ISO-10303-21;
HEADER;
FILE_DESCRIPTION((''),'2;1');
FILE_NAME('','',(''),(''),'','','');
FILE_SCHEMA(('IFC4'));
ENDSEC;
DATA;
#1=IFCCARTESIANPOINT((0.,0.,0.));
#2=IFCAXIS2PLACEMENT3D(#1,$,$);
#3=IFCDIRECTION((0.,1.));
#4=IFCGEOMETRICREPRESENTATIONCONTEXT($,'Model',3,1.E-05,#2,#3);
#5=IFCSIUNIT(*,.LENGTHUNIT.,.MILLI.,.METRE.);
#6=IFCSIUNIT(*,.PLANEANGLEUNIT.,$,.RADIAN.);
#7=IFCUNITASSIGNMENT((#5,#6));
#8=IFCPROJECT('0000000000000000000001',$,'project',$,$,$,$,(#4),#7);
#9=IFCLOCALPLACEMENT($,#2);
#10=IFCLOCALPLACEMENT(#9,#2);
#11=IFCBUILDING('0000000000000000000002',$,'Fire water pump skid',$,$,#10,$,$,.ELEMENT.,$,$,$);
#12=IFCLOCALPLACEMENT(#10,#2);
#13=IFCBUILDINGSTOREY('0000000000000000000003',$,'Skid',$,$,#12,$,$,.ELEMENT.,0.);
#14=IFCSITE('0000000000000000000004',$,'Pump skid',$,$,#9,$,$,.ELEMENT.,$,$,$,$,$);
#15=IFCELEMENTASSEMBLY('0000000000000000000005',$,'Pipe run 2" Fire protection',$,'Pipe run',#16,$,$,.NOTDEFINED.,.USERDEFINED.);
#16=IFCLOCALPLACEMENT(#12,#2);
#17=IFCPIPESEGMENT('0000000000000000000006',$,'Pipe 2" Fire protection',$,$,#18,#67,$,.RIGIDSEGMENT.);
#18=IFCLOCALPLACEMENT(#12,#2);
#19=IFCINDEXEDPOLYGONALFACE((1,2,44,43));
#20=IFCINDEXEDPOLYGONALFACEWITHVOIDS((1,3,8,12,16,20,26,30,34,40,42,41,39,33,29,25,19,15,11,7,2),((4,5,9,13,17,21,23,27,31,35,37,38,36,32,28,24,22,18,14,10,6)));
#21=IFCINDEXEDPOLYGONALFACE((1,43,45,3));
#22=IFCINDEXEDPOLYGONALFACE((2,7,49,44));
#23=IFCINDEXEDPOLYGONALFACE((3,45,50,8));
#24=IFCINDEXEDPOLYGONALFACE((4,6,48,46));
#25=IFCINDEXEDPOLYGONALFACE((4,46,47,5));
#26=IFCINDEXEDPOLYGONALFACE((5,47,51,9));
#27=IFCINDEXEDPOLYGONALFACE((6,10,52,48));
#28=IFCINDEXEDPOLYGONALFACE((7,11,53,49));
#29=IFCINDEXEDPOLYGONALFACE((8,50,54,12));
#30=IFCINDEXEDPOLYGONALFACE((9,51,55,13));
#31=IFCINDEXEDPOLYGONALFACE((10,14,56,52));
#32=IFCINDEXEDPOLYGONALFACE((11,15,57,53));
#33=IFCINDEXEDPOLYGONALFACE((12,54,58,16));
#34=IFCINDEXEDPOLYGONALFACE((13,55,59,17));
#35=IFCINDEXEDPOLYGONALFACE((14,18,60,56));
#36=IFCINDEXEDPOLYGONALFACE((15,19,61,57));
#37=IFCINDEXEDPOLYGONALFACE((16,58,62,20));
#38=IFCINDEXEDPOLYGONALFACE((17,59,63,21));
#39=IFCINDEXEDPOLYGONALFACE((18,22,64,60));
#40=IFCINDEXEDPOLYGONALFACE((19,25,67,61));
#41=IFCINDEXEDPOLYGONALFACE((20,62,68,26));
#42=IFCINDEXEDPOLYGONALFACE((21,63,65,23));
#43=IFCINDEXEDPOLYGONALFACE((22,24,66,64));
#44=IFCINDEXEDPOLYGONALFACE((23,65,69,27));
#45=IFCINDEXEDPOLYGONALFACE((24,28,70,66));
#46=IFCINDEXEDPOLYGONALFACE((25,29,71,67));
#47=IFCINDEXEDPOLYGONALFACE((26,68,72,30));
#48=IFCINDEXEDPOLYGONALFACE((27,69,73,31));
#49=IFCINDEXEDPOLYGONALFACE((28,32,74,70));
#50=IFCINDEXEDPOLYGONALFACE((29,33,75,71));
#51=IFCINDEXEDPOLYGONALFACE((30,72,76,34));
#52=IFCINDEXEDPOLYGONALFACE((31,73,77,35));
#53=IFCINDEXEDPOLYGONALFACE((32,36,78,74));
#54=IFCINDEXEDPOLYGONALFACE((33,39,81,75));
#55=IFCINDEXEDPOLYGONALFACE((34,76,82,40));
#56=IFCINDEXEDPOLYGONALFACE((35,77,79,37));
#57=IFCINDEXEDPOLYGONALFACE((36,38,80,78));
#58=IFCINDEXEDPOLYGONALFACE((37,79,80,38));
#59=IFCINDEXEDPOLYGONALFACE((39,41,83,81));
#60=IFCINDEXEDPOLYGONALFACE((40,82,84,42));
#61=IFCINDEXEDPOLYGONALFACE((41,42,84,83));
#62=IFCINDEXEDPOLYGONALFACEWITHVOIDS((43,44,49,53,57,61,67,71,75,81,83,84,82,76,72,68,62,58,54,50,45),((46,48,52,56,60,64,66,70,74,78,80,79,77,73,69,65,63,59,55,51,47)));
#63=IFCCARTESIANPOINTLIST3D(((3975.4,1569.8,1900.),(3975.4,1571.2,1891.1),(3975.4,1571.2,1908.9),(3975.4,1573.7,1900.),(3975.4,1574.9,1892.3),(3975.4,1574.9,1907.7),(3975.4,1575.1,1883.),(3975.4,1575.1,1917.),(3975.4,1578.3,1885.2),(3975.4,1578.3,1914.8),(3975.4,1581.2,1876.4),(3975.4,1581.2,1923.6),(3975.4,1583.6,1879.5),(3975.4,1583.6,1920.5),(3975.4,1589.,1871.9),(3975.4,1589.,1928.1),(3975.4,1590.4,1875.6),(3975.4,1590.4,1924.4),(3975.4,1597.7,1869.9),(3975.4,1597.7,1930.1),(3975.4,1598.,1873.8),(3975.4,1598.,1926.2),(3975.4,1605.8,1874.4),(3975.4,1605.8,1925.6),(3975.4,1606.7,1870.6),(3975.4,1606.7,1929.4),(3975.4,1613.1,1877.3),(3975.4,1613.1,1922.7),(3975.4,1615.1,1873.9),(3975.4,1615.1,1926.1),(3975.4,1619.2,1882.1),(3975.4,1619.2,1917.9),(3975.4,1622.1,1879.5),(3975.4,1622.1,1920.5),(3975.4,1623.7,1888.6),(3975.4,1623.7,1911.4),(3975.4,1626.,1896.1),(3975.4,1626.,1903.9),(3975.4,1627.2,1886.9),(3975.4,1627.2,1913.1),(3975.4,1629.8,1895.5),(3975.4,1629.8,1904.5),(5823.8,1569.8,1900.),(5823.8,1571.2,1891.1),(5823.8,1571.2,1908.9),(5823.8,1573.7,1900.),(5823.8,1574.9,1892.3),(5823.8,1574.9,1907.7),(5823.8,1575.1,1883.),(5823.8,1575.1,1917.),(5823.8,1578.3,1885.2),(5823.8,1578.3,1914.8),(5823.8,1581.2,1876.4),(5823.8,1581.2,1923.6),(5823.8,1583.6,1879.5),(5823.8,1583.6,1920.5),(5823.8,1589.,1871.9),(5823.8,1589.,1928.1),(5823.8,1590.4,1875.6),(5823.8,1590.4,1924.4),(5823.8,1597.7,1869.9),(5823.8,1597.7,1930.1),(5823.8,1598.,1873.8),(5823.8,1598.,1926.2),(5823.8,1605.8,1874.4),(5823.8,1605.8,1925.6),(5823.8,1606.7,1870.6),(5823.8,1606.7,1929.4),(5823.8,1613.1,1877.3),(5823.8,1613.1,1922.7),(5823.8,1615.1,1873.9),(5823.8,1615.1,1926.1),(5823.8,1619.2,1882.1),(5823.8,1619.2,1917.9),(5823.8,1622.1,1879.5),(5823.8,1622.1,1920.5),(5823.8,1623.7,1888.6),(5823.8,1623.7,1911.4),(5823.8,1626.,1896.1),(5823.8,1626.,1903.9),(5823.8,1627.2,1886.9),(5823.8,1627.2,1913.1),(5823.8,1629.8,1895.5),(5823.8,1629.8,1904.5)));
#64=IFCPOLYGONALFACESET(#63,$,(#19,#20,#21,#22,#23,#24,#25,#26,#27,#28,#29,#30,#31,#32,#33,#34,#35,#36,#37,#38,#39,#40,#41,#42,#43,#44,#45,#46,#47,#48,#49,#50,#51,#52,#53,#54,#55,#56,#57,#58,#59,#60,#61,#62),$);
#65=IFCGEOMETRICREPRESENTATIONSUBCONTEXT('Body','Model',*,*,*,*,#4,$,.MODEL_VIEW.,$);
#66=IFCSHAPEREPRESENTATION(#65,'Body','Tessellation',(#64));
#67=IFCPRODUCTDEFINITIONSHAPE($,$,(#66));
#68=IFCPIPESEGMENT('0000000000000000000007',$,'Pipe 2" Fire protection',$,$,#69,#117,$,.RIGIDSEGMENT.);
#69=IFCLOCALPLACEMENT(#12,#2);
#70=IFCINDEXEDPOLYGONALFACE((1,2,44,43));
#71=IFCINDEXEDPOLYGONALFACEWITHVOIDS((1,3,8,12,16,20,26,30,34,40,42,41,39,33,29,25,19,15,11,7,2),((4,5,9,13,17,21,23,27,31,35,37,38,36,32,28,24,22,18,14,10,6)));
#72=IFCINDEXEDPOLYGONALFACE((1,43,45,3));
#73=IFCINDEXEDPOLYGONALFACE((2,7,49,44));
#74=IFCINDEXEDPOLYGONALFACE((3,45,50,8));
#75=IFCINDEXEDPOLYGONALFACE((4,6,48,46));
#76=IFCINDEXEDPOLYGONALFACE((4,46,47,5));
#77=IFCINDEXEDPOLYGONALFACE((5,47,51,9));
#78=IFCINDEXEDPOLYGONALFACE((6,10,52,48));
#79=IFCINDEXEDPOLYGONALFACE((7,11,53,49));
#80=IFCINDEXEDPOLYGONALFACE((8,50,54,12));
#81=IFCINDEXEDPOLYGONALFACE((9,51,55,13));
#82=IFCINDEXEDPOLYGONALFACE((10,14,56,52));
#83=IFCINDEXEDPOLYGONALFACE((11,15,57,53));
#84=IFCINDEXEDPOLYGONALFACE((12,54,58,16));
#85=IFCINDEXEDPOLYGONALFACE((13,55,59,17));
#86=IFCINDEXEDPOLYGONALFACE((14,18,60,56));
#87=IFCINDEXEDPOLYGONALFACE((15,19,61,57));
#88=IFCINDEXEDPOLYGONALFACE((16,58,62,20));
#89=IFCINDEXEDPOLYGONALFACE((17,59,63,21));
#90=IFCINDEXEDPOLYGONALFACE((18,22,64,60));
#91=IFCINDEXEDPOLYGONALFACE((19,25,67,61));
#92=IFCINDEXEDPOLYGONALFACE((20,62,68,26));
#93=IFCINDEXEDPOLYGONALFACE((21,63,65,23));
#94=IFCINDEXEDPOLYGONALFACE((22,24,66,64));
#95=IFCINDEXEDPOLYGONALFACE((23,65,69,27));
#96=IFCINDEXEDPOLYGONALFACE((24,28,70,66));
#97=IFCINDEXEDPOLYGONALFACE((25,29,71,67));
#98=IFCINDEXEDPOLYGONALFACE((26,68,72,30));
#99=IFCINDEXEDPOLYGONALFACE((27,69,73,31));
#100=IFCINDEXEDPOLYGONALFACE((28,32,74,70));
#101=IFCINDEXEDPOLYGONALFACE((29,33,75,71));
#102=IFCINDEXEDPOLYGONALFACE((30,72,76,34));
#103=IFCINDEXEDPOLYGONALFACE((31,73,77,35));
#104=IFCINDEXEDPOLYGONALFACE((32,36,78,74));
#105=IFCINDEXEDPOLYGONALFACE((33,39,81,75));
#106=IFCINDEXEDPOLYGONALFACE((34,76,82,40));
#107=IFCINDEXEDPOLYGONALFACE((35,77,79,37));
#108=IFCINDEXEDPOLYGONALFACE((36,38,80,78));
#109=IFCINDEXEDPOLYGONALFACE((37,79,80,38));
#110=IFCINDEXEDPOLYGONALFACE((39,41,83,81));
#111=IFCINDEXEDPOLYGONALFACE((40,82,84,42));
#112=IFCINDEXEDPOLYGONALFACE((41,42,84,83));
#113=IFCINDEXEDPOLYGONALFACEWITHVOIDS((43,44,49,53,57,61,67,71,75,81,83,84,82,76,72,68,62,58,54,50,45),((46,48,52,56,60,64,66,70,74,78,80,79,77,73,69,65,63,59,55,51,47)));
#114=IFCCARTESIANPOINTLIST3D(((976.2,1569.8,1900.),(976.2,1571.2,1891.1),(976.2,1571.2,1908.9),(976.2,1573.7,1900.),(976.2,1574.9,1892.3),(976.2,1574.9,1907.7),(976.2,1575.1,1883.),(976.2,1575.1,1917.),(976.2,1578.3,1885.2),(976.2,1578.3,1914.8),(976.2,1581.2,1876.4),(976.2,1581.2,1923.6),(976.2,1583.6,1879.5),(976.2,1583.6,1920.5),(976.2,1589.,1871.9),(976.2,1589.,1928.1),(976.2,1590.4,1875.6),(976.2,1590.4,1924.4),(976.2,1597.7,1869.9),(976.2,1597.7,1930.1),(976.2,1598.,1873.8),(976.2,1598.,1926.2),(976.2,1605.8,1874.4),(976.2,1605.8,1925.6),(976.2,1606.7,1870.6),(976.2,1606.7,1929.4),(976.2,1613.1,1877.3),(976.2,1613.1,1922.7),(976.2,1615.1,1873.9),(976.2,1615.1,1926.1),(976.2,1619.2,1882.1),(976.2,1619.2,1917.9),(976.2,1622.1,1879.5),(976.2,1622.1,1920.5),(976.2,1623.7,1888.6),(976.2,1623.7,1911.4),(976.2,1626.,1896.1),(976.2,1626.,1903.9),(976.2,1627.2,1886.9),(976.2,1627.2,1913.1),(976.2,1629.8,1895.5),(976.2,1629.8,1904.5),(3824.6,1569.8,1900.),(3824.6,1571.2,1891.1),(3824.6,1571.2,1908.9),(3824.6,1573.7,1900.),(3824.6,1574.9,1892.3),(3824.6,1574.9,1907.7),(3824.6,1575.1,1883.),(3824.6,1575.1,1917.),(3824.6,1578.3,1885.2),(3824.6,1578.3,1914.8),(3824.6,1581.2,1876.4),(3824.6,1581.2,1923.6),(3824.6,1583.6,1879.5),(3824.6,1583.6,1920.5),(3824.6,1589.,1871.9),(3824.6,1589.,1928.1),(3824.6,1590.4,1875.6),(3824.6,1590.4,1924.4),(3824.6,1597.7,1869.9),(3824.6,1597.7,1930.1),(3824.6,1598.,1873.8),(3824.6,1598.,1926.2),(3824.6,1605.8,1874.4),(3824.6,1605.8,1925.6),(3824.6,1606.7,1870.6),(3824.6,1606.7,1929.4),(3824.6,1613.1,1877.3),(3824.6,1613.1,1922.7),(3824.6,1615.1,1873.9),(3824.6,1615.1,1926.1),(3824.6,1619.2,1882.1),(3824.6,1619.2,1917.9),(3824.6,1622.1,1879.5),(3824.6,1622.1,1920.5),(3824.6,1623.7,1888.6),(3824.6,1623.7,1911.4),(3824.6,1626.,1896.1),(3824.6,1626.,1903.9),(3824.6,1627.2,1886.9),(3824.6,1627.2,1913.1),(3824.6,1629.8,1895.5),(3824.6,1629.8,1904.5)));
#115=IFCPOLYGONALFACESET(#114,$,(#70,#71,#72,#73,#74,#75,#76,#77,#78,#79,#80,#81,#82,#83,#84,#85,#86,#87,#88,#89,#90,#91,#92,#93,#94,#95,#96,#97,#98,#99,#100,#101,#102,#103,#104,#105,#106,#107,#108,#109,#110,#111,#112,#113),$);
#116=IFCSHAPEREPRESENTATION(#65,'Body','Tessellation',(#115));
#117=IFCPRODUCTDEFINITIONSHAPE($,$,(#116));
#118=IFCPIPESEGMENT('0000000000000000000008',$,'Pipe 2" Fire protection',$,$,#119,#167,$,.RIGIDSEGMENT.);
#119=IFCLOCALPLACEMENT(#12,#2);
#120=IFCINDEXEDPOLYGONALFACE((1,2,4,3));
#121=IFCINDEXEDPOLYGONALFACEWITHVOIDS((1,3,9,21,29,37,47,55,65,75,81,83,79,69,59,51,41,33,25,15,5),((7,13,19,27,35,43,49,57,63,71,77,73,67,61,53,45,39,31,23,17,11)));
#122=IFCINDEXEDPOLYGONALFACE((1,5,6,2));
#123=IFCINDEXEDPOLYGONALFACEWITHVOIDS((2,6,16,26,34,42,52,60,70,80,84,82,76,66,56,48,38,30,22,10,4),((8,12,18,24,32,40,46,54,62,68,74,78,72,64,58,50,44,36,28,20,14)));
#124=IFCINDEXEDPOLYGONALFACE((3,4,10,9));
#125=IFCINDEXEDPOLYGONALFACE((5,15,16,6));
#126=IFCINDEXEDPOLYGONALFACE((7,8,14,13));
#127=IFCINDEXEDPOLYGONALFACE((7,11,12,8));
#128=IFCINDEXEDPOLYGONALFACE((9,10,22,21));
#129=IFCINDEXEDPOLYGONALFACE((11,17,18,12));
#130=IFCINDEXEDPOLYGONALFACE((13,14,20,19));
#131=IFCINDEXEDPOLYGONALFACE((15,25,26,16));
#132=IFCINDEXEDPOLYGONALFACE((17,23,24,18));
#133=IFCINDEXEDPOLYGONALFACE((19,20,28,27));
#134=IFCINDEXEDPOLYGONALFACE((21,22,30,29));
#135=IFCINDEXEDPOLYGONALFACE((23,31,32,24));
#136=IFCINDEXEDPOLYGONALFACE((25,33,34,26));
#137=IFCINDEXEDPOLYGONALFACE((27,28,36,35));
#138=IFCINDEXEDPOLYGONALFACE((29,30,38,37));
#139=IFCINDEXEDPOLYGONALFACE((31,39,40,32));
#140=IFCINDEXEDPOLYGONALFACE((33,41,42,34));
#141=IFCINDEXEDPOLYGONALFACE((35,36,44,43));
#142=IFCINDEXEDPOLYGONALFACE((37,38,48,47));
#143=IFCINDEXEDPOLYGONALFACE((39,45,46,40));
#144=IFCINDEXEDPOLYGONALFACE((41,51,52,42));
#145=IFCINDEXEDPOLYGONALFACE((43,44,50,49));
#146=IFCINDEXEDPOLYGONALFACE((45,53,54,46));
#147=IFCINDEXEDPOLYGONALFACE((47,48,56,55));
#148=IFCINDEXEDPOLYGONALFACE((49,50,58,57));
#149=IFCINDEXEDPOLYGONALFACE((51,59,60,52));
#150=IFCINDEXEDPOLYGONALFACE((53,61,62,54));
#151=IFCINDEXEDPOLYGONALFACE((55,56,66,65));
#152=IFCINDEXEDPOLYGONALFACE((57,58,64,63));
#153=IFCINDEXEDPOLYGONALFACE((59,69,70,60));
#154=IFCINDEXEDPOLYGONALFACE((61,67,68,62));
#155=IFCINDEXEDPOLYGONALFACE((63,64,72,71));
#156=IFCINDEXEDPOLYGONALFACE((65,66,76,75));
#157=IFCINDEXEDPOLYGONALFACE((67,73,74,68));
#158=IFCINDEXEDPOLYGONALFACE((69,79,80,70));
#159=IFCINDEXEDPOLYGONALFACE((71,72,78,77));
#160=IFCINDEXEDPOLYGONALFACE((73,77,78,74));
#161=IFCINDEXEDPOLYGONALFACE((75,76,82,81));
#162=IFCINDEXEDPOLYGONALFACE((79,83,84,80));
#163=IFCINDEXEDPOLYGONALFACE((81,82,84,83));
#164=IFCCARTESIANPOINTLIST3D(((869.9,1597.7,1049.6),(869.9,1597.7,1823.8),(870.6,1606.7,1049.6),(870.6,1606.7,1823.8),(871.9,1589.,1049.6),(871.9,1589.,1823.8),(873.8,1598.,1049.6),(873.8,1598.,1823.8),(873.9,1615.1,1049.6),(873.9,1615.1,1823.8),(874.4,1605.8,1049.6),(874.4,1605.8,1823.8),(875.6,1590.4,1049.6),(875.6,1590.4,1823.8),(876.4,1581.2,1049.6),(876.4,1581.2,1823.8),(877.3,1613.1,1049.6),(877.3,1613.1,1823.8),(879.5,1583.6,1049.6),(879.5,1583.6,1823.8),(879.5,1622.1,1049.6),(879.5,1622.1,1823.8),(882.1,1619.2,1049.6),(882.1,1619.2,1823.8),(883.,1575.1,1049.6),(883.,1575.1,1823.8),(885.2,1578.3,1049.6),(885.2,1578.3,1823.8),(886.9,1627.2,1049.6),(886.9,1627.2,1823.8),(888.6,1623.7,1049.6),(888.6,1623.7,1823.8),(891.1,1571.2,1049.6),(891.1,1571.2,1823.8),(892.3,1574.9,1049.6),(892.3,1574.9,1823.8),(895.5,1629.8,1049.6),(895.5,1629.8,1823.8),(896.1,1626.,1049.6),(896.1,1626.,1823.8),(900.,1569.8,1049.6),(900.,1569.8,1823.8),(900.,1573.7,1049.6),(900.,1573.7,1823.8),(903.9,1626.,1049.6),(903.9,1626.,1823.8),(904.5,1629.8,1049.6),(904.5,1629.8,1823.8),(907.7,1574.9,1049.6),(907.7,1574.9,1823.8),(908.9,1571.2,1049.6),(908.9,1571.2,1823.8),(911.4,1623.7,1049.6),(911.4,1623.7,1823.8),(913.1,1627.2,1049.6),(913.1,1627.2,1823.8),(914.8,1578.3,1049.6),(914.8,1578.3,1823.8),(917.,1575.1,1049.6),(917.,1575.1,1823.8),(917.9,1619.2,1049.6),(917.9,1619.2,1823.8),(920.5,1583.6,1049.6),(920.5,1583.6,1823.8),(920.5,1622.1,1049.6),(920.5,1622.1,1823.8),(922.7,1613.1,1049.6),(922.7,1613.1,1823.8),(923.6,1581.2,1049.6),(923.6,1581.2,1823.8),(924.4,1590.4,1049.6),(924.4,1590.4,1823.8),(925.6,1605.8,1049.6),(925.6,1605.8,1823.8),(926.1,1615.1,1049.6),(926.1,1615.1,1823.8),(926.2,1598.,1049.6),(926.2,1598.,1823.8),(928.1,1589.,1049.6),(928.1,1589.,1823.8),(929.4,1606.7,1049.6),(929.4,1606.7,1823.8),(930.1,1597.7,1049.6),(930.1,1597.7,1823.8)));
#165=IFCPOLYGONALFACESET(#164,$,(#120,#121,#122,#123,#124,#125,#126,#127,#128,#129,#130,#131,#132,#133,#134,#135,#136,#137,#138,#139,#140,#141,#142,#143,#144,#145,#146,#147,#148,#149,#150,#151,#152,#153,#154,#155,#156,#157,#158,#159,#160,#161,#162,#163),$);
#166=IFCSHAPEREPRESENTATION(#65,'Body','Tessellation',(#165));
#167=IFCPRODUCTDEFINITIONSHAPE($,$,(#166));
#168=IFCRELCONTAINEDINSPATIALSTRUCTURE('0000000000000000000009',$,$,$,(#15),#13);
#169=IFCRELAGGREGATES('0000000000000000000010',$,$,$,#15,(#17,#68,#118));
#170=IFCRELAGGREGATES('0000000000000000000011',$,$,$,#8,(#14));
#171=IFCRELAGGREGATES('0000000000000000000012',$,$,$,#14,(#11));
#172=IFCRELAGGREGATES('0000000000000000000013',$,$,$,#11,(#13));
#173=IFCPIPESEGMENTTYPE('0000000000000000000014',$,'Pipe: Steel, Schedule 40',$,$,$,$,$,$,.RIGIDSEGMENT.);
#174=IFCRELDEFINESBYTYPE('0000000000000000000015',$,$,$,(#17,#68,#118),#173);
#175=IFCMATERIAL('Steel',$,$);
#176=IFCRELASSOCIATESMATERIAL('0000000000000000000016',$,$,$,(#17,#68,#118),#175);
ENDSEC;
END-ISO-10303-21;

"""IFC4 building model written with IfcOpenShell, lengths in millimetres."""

from ifc_helpers import new_model, si_unit, direction, frame, origin, origin_with_axes, origin_2d, place, context, subcontext, project, spatial, hollow_circle, extrude, material, type_object, element, aggregate, save


model = new_model("IFC4")

# Units and contexts
model_context = context("Model", 3, precision=1e-05, world=origin(), true_north=direction((0.0, 1.0)))
body_context = subcontext(model_context, "Body", "Model", "MODEL_VIEW")
ifc_project = project(units=[si_unit("LENGTHUNIT", "METRE", prefix="MILLI"), si_unit("PLANEANGLEUNIT", "RADIAN")], contexts=[model_context])

# Site, building, storey
site_placement = place(None, origin())
site = spatial("IfcSite", under=ifc_project, at=site_placement, Name="Pump skid", CompositionType="ELEMENT")
building_placement = place(site_placement, origin())
building = spatial("IfcBuilding", under=site, at=building_placement, Name="Fire water pump skid", CompositionType="ELEMENT")
storey_placement = place(building_placement, origin())
storey = spatial("IfcBuildingStorey", under=building, at=storey_placement, Name="Skid", CompositionType="ELEMENT", Elevation=0.0)

# Element assembly, pipe segments
ifc_material = material(Name="Steel")
pipe_segment_type = type_object("IfcPipeSegmentType", Name="Pipe: Steel, Schedule 40", PredefinedType="RIGIDSEGMENT")
assembly_1_placement = place(storey_placement, origin_with_axes())
assembly_1 = element("IfcElementAssembly", 1, at=assembly_1_placement, inside=storey, Name="Pipe run 2\" Fire protection", ObjectType="Pipe run", AssemblyPlace="NOTDEFINED", PredefinedType="USERDEFINED")
pipe_segment_1_placement = place(storey_placement, origin_with_axes())
pipe_segment_1 = element("IfcPipeSegment", 2, at=pipe_segment_1_placement, type_object=pipe_segment_type, material=ifc_material, Name="Pipe 2\" Fire protection", PredefinedType="RIGIDSEGMENT", context=body_context, shape_type="SweptSolid", body=[
    extrude(hollow_circle(Radius=30.2, WallThickness=3.9, at=origin_2d()), frame((5823.8, 1600.0, 1900.0), z_axis=(-1.0, 0.0, 0.0), x_axis=(0.0, -1.0, 0.0)), (0.0, 0.0, 1.0), 1848.4),
])
pipe_segment_2_placement = place(storey_placement, origin_with_axes())
pipe_segment_2 = element("IfcPipeSegment", 3, at=pipe_segment_2_placement, type_object=pipe_segment_type, material=ifc_material, Name="Pipe 2\" Fire protection", PredefinedType="RIGIDSEGMENT", context=body_context, shape_type="SweptSolid", body=[
    extrude(hollow_circle(Radius=30.2, WallThickness=3.9, at=origin_2d()), frame((3824.6, 1600.0, 1900.0), z_axis=(-1.0, 0.0, 0.0), x_axis=(0.0, -1.0, 0.0)), (0.0, 0.0, 1.0), 2848.4),
])
pipe_segment_3_placement = place(storey_placement, origin_with_axes())
pipe_segment_3 = element("IfcPipeSegment", 4, at=pipe_segment_3_placement, type_object=pipe_segment_type, material=ifc_material, Name="Pipe 2\" Fire protection", PredefinedType="RIGIDSEGMENT", context=body_context, shape_type="SweptSolid", body=[
    extrude(hollow_circle(Radius=30.2, WallThickness=3.9, at=origin_2d()), frame((900.0, 1600.0, 1823.8), z_axis=(0.0, 0.0, -1.0), x_axis=(0.0, -1.0, 0.0)), (0.0, 0.0, 1.0), 774.2),
])

aggregate(assembly_1, [pipe_segment_1, pipe_segment_2, pipe_segment_3])

save(model, "model.ifc")
